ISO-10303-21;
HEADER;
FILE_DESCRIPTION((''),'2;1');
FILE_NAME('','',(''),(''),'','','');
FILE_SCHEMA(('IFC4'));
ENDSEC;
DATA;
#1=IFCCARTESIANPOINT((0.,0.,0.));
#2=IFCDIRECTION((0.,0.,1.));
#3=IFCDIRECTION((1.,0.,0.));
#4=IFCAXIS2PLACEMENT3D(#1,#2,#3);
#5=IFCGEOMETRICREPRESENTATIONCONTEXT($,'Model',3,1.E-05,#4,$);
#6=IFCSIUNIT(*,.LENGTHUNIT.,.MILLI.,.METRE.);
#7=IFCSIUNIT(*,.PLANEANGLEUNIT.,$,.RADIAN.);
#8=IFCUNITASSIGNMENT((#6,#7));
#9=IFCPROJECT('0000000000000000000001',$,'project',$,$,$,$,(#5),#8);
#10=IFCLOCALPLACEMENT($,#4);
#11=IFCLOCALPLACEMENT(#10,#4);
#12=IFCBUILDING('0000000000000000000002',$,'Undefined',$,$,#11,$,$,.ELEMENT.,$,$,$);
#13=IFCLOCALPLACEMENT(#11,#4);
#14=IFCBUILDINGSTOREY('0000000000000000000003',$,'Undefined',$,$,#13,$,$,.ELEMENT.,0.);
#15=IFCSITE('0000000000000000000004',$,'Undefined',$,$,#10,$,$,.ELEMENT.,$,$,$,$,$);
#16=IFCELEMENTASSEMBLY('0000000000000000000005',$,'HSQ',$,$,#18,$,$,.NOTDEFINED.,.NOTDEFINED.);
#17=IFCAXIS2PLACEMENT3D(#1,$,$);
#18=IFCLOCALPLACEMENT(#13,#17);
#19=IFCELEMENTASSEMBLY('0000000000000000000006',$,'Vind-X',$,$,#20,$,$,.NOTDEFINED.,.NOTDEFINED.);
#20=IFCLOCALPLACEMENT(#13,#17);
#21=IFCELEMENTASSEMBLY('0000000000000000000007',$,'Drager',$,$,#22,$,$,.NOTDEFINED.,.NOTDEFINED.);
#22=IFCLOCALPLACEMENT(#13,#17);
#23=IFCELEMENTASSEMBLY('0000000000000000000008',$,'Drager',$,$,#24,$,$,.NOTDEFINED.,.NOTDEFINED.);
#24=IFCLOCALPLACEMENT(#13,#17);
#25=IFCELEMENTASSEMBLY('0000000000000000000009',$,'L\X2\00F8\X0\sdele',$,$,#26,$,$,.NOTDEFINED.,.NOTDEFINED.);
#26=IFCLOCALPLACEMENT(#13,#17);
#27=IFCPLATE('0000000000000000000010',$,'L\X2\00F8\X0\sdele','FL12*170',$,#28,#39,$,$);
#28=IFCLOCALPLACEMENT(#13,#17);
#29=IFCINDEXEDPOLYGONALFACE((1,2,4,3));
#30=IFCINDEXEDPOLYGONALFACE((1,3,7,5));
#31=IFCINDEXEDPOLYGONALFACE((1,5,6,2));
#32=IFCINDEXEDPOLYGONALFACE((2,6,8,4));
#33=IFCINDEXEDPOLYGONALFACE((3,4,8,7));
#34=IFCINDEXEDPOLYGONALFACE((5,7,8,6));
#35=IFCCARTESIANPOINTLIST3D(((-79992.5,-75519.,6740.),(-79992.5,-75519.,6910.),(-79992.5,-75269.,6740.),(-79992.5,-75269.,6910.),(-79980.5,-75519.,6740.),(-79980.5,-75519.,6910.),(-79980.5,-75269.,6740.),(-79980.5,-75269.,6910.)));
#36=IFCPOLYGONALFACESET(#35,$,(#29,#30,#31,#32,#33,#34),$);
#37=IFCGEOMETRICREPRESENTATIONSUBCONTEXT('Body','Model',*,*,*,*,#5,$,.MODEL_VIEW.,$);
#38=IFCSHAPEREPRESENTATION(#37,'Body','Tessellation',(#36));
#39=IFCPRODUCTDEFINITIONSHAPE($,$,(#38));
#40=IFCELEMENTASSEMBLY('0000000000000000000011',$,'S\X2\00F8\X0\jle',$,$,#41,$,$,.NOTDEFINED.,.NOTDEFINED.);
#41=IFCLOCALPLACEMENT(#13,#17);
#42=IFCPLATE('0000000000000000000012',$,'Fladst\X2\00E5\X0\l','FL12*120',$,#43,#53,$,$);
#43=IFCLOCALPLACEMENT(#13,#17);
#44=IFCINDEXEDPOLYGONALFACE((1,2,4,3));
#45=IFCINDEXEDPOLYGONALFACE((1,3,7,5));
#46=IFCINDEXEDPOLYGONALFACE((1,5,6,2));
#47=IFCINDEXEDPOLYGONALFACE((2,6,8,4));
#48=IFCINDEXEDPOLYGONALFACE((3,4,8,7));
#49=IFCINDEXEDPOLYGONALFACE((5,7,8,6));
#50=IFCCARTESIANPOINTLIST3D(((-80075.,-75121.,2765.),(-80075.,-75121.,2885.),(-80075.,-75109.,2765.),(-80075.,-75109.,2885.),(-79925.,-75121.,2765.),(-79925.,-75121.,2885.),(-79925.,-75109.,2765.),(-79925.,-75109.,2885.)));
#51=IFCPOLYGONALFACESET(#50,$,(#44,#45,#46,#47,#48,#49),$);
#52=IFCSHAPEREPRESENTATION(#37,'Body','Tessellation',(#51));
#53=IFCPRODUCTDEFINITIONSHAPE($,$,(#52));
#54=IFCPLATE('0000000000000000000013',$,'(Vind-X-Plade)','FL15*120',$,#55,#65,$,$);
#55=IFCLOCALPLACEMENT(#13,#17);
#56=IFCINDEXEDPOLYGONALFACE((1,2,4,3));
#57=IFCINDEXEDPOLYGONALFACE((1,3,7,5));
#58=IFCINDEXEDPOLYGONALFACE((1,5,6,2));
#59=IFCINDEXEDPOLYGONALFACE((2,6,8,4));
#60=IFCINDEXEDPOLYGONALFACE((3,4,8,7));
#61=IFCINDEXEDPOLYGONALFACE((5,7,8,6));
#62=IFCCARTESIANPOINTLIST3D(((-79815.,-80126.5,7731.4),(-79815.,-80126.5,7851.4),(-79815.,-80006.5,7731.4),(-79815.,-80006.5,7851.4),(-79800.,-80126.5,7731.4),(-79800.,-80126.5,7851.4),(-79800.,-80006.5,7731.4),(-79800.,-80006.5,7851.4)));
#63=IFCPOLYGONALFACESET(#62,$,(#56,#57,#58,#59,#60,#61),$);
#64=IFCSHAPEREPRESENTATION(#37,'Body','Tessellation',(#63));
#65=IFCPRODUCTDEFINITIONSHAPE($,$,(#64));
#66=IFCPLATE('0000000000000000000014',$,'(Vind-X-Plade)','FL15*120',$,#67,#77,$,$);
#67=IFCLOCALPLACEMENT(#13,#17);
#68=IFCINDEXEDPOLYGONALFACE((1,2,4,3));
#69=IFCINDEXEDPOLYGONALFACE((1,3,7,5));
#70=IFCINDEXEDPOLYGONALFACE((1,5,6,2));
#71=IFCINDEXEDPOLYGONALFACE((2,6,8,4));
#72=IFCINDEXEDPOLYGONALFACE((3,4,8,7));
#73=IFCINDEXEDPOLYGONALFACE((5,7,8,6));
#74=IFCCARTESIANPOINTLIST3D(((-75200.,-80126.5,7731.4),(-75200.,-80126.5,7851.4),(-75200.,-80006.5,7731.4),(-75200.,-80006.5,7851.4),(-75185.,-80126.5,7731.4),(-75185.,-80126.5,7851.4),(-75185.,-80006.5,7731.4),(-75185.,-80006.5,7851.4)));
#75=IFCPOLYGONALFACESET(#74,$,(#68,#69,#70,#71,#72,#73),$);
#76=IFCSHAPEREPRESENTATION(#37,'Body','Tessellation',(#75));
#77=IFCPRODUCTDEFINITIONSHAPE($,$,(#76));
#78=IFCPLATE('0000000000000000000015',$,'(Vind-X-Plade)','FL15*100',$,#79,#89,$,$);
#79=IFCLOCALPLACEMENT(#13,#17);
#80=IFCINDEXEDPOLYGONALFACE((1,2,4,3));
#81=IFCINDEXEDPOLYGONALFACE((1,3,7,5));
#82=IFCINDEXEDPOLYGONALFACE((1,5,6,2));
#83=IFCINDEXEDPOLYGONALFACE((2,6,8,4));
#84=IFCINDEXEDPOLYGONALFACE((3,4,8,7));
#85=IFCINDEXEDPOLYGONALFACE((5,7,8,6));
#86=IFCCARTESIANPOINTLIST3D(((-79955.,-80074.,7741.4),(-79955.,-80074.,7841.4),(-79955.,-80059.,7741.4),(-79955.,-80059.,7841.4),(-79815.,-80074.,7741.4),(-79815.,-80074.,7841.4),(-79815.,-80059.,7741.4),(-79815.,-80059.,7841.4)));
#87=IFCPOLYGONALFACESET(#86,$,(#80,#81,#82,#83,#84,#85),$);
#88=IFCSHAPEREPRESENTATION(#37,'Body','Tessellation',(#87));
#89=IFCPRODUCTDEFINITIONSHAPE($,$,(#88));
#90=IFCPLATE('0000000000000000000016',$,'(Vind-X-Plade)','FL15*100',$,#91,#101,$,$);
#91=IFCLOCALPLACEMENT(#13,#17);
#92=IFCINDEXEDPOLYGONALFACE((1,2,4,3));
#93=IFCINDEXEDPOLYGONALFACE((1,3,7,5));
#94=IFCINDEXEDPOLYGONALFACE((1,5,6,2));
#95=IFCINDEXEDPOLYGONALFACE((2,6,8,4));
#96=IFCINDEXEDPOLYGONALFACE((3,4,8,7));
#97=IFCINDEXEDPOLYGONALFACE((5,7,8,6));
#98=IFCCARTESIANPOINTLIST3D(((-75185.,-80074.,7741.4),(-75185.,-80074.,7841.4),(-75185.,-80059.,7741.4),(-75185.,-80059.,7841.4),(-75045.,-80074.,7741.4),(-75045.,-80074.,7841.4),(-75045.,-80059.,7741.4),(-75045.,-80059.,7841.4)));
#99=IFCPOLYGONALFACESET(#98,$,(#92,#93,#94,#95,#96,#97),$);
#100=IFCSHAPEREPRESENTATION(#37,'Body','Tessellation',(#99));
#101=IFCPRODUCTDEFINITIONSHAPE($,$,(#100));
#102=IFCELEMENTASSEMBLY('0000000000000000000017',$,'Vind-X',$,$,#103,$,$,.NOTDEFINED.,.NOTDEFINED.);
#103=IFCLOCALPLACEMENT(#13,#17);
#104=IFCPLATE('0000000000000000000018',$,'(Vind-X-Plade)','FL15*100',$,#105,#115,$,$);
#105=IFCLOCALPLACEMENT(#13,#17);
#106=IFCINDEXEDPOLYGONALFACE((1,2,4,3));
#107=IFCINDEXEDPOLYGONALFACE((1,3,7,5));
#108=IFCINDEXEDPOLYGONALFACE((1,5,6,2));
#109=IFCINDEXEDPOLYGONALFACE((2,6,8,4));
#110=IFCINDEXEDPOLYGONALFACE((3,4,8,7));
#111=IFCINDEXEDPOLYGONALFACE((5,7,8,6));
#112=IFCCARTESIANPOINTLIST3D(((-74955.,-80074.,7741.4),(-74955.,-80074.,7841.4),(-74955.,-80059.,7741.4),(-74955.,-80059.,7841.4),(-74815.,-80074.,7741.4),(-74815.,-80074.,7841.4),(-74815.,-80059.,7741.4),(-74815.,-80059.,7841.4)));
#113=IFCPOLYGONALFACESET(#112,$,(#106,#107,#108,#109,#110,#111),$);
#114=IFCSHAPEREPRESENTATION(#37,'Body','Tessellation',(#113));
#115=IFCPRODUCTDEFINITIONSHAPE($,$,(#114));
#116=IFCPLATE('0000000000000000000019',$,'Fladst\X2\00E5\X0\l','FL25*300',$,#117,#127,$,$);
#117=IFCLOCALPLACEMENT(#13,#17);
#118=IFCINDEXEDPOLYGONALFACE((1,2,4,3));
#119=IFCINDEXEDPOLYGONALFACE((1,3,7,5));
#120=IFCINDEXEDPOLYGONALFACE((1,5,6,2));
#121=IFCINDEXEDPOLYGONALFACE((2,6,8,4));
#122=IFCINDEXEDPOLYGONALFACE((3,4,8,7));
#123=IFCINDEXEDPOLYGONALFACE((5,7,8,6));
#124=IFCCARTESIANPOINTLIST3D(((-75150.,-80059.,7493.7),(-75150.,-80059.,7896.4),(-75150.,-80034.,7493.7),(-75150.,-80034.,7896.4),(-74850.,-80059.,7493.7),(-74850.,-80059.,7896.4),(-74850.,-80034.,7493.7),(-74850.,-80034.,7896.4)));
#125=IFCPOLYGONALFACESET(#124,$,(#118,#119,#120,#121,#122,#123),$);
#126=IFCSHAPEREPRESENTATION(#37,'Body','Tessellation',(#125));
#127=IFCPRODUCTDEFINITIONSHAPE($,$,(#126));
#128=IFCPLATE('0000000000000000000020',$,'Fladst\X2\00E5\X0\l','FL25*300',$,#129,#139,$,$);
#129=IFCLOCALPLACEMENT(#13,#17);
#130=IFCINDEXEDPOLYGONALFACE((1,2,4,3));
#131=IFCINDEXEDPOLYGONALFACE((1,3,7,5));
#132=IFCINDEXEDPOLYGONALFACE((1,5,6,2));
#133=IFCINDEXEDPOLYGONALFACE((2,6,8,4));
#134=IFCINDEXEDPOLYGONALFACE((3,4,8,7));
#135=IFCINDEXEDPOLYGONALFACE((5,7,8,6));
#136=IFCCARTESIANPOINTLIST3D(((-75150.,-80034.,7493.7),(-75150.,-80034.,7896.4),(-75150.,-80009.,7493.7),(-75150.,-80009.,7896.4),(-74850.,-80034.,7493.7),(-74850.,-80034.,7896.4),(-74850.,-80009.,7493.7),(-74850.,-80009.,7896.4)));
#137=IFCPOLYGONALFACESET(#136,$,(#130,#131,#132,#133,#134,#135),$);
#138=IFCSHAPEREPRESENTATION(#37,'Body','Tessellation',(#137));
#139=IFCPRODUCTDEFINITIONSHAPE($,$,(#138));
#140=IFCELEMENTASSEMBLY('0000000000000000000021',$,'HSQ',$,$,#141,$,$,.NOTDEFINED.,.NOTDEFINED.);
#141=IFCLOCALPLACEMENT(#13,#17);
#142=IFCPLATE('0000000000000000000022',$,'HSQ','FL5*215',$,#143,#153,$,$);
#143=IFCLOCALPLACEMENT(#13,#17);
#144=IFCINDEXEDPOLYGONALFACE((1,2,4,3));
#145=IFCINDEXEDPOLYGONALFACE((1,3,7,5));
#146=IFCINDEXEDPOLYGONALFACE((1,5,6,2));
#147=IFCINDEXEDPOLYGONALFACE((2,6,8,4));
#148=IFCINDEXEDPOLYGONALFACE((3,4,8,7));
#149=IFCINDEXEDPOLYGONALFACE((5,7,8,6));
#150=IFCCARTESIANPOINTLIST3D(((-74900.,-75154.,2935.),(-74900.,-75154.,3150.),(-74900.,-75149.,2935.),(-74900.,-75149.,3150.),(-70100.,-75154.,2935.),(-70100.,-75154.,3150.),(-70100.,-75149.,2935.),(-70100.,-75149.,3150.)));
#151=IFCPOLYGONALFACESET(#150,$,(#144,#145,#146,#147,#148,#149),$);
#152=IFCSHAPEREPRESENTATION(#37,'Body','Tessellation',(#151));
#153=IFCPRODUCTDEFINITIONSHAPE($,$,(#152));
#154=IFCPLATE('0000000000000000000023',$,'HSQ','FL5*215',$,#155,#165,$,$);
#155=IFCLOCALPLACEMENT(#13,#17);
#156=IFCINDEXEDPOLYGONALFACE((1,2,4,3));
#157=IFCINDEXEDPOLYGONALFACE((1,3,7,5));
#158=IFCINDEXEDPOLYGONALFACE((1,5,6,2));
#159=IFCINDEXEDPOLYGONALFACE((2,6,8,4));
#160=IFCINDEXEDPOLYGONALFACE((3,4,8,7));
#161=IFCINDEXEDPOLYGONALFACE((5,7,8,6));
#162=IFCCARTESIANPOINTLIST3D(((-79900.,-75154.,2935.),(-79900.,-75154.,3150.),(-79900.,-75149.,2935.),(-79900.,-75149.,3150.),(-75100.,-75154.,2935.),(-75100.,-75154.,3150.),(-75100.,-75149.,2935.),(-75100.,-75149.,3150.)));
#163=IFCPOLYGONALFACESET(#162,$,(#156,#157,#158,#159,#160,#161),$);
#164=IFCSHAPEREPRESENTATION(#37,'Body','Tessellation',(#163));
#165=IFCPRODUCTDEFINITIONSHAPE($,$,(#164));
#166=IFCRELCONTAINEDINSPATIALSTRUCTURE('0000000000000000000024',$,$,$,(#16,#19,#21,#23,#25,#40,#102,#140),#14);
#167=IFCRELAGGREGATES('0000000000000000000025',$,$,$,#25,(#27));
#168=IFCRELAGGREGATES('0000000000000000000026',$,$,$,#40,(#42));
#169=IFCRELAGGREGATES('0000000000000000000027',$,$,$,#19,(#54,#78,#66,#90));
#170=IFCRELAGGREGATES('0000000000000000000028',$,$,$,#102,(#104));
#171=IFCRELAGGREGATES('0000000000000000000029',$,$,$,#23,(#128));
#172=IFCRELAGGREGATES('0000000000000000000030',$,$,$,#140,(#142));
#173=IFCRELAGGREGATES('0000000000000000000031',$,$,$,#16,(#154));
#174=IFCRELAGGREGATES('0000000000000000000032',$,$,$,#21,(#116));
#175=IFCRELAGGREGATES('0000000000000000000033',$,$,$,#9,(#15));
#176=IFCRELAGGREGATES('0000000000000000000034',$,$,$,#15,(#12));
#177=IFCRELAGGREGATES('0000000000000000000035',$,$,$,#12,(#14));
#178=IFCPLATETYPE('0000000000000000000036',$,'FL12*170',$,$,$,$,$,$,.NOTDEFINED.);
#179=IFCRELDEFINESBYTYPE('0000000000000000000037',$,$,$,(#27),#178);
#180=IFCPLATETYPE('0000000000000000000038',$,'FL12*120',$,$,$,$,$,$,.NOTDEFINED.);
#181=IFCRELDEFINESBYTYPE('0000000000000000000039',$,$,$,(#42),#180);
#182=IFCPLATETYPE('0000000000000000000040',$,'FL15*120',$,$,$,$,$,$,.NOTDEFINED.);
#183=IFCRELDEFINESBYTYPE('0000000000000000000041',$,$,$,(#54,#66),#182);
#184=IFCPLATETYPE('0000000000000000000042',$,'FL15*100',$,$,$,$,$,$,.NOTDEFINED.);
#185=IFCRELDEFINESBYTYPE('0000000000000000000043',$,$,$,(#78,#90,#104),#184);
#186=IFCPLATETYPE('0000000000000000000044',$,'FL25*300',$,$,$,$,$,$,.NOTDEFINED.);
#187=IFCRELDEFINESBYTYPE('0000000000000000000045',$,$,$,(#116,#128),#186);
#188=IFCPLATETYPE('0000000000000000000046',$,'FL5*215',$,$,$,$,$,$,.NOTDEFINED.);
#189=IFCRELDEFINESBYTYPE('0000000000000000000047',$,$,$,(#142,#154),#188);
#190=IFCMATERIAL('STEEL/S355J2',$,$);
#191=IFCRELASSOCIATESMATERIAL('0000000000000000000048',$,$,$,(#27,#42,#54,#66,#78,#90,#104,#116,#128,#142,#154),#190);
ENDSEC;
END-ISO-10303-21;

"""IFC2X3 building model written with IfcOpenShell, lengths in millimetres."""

from ifc_helpers import new_model, si_unit, frame, origin_with_axes, place, context, subcontext, project, spatial, polyline, outline, extrude, material, type_object, element, aggregate, save


model = new_model("IFC2X3")

# Units and contexts
model_context = context("Model", 3, precision=1e-05, world=origin_with_axes())
body_context = subcontext(model_context, "Body", "Model", "MODEL_VIEW")
ifc_project = project(units=[si_unit("LENGTHUNIT", "METRE", prefix="MILLI"), si_unit("PLANEANGLEUNIT", "RADIAN")], contexts=[model_context])

# Site, building, storey
site_placement = place(None, origin_with_axes())
site = spatial("IfcSite", under=ifc_project, at=site_placement, Name="Undefined", CompositionType="ELEMENT")
building_placement = place(site_placement, origin_with_axes())
building = spatial("IfcBuilding", under=site, at=building_placement, Name="Undefined", CompositionType="ELEMENT")
storey_placement = place(building_placement, origin_with_axes())
storey = spatial("IfcBuildingStorey", under=building, at=storey_placement, Name="Undefined", CompositionType="ELEMENT", Elevation=0.0)

# Element assembly
assembly_1_placement = place(storey_placement, origin_with_axes())
assembly_1 = element("IfcElementAssembly", 1, at=assembly_1_placement, inside=storey, Name="HSQ", AssemblyPlace="NOTDEFINED", PredefinedType="NOTDEFINED")

# Element assemblies
assembly_2_placement = place(storey_placement, origin_with_axes())
assembly_2 = element("IfcElementAssembly", 2, at=assembly_2_placement, inside=storey, Name="Vind-X", AssemblyPlace="NOTDEFINED", PredefinedType="NOTDEFINED")
assembly_3_placement = place(storey_placement, origin_with_axes())
assembly_3 = element("IfcElementAssembly", 3, at=assembly_3_placement, inside=storey, Name="Drager", AssemblyPlace="NOTDEFINED", PredefinedType="NOTDEFINED")
ifc_material_1 = material(Name="STEEL/S355J2")
assembly_4_placement = place(storey_placement, origin_with_axes())
assembly_4 = element("IfcElementAssembly", 4, at=assembly_4_placement, inside=storey, Name="Drager", AssemblyPlace="NOTDEFINED", PredefinedType="NOTDEFINED")

# Element assemblies, plates
plate_type_1 = type_object("IfcPlateType", Name="FL12*170", PredefinedType="NOTDEFINED")
assembly_5_placement = place(storey_placement, origin_with_axes())
assembly_5 = element("IfcElementAssembly", 5, at=assembly_5_placement, inside=storey, Name="Løsdele", AssemblyPlace="NOTDEFINED", PredefinedType="NOTDEFINED")
plate_1_placement = place(assembly_5_placement, frame((-79986.5, -75269.0, 6825.0), z_axis=(-1.0, 0.0, 0.0), x_axis=(0.0, -1.0, 0.0)))
plate_1 = element("IfcPlate", 6, at=plate_1_placement, type_object=plate_type_1, material=ifc_material_1, Name="Løsdele", Description="FL12*170", context=body_context, shape_type="SweptSolid", body=[
    extrude(outline(polyline([(0.0, -85.0), (0.0, 85.0), (250.0, 85.0), (250.0, -85.0), (0.0, -85.0)])), frame((0.0, 0.0, -6.0), z_axis=(0.0, 0.0, 1.0), x_axis=(1.0, 0.0, 0.0)), (0.0, 0.0, 1.0), 12.0),
])
aggregate(assembly_5, [plate_1])
assembly_6_placement = place(storey_placement, origin_with_axes())
assembly_6 = element("IfcElementAssembly", 7, at=assembly_6_placement, inside=storey, Name="Søjle", AssemblyPlace="NOTDEFINED", PredefinedType="NOTDEFINED")
plate_type_2 = type_object("IfcPlateType", Name="FL12*120", PredefinedType="NOTDEFINED")
plate_2_placement = place(assembly_6_placement, frame((-79925.0, -75115.0, 2885.0), z_axis=(0.0, -1.0, 0.0), x_axis=(-1.0, 0.0, 0.0)))
plate_2 = element("IfcPlate", 8, at=plate_2_placement, type_object=plate_type_2, material=ifc_material_1, Name="Fladstål", Description="FL12*120", context=body_context, shape_type="SweptSolid", body=[
    extrude(outline(polyline([(0.0, 0.0), (150.0, 0.0), (150.0, 120.0), (0.0, 120.0), (0.0, 0.0)])), frame((0.0, 0.0, -6.0), z_axis=(0.0, 0.0, 1.0), x_axis=(1.0, 0.0, 0.0)), (0.0, 0.0, 1.0), 12.0),
])
aggregate(assembly_6, [plate_2])

# Plates
plate_type_3 = type_object("IfcPlateType", Name="FL15*120", PredefinedType="NOTDEFINED")
plate_3_placement = place(assembly_2_placement, frame((-79807.5, -80126.5, 7851.4), z_axis=(-1.0, 0.0, 0.0), x_axis=(0.0, 1.0, 0.0)))
plate_3 = element("IfcPlate", 9, at=plate_3_placement, type_object=plate_type_3, material=ifc_material_1, Name="(Vind-X-Plade)", Description="FL15*120", context=body_context, shape_type="SweptSolid", body=[
    extrude(outline(polyline([(0.0, 0.0), (120.0, 0.0), (120.0, 120.0), (0.0, 120.0), (0.0, 0.0)])), frame((0.0, 0.0, -7.5), z_axis=(0.0, 0.0, 1.0), x_axis=(1.0, 0.0, 0.0)), (0.0, 0.0, 1.0), 15.0),
])
plate_4_placement = place(assembly_2_placement, frame((-75192.5, -80006.5, 7851.4), z_axis=(1.0, 0.0, 0.0), x_axis=(0.0, -1.0, 0.0)))
plate_4 = element("IfcPlate", 10, at=plate_4_placement, type_object=plate_type_3, material=ifc_material_1, Name="(Vind-X-Plade)", Description="FL15*120", context=body_context, shape_type="SweptSolid", body=[
    extrude(outline(polyline([(0.0, 0.0), (120.0, 0.0), (120.0, 120.0), (0.0, 120.0), (0.0, 0.0)])), frame((0.0, 0.0, -7.5), z_axis=(0.0, 0.0, 1.0), x_axis=(1.0, 0.0, 0.0)), (0.0, 0.0, 1.0), 15.0),
])
plate_type_4 = type_object("IfcPlateType", Name="FL15*100", PredefinedType="NOTDEFINED")
plate_5_placement = place(assembly_2_placement, frame((-79955.0, -80066.5, 7741.4), z_axis=(0.0, 1.0, 0.0), x_axis=(0.0, 0.0, 1.0)))
plate_5 = element("IfcPlate", 11, at=plate_5_placement, type_object=plate_type_4, material=ifc_material_1, Name="(Vind-X-Plade)", Description="FL15*100", context=body_context, shape_type="SweptSolid", body=[
    extrude(outline(polyline([(0.0, 0.0), (100.0, 0.0), (100.0, 140.0), (0.0, 140.0), (0.0, 0.0)])), frame((0.0, 0.0, -7.5), z_axis=(0.0, 0.0, 1.0), x_axis=(1.0, 0.0, 0.0)), (0.0, 0.0, 1.0), 15.0),
])
plate_6_placement = place(assembly_2_placement, frame((-75045.0, -80066.5, 7741.4), z_axis=(0.0, -1.0, 0.0), x_axis=(0.0, 0.0, 1.0)))
plate_6 = element("IfcPlate", 12, at=plate_6_placement, type_object=plate_type_4, material=ifc_material_1, Name="(Vind-X-Plade)", Description="FL15*100", context=body_context, shape_type="SweptSolid", body=[
    extrude(outline(polyline([(0.0, 0.0), (100.0, 0.0), (100.0, 140.0), (0.0, 140.0), (0.0, 0.0)])), frame((0.0, 0.0, -7.5), z_axis=(0.0, 0.0, 1.0), x_axis=(1.0, 0.0, 0.0)), (0.0, 0.0, 1.0), 15.0),
])
aggregate(assembly_2, [plate_3, plate_5, plate_4, plate_6])

# Element assembly, plate
assembly_7_placement = place(storey_placement, origin_with_axes())
assembly_7 = element("IfcElementAssembly", 13, at=assembly_7_placement, inside=storey, Name="Vind-X", AssemblyPlace="NOTDEFINED", PredefinedType="NOTDEFINED")
plate_7_placement = place(assembly_7_placement, frame((-74955.0, -80066.5, 7741.4), z_axis=(0.0, 1.0, 0.0), x_axis=(0.0, 0.0, 1.0)))
plate_7 = element("IfcPlate", 14, at=plate_7_placement, type_object=plate_type_4, material=ifc_material_1, Name="(Vind-X-Plade)", Description="FL15*100", context=body_context, shape_type="SweptSolid", body=[
    extrude(outline(polyline([(0.0, 0.0), (100.0, 0.0), (100.0, 140.0), (0.0, 140.0), (0.0, 0.0)])), frame((0.0, 0.0, -7.5), z_axis=(0.0, 0.0, 1.0), x_axis=(1.0, 0.0, 0.0)), (0.0, 0.0, 1.0), 15.0),
])
aggregate(assembly_7, [plate_7])

# Plates
plate_type_5 = type_object("IfcPlateType", Name="FL25*300", PredefinedType="NOTDEFINED")
plate_8_placement = place(assembly_3_placement, frame((-75000.0, -80046.5, 7493.7), z_axis=(0.0, -1.0, 0.0), x_axis=(0.0, 0.0, 1.0)))
plate_8 = element("IfcPlate", 15, at=plate_8_placement, type_object=plate_type_5, material=ifc_material_1, Name="Fladstål", Description="FL25*300", context=body_context, shape_type="SweptSolid", body=[
    extrude(outline(polyline([(0.0, -150.0), (0.0, 150.0), (402.7, 150.0), (402.7, -150.0), (0.0, -150.0)])), frame((0.0, 0.0, -12.5), z_axis=(0.0, 0.0, 1.0), x_axis=(1.0, 0.0, 0.0)), (0.0, 0.0, 1.0), 25.0),
])
plate_9_placement = place(assembly_4_placement, frame((-75000.0, -80021.5, 7493.7), z_axis=(0.0, -1.0, 0.0), x_axis=(0.0, 0.0, 1.0)))
plate_9 = element("IfcPlate", 16, at=plate_9_placement, type_object=plate_type_5, material=ifc_material_1, Name="Fladstål", Description="FL25*300", context=body_context, shape_type="SweptSolid", body=[
    extrude(outline(polyline([(0.0, -150.0), (0.0, 150.0), (402.7, 150.0), (402.7, -150.0), (0.0, -150.0)])), frame((0.0, 0.0, -12.5), z_axis=(0.0, 0.0, 1.0), x_axis=(1.0, 0.0, 0.0)), (0.0, 0.0, 1.0), 25.0),
])
aggregate(assembly_4, [plate_9])

# Element assembly, plate
assembly_8_placement = place(storey_placement, origin_with_axes())
assembly_8 = element("IfcElementAssembly", 17, at=assembly_8_placement, inside=storey, Name="HSQ", AssemblyPlace="NOTDEFINED", PredefinedType="NOTDEFINED")
plate_type_6 = type_object("IfcPlateType", Name="FL5*215", PredefinedType="NOTDEFINED")
plate_10_placement = place(assembly_8_placement, frame((-74900.0, -75151.5, 3042.5), z_axis=(0.0, -1.0, 0.0), x_axis=(1.0, 0.0, 0.0)))
plate_10 = element("IfcPlate", 18, at=plate_10_placement, type_object=plate_type_6, material=ifc_material_1, Name="HSQ", Description="FL5*215", context=body_context, shape_type="SweptSolid", body=[
    extrude(outline(polyline([(0.0, -107.5), (0.0, 107.5), (4800.0, 107.5), (4800.0, -107.5), (0.0, -107.5)])), frame((0.0, 0.0, -2.5), z_axis=(0.0, 0.0, 1.0), x_axis=(1.0, 0.0, 0.0)), (0.0, 0.0, 1.0), 5.0),
])

# Plate
plate_11_placement = place(assembly_1_placement, frame((-79900.0, -75151.5, 3042.5), z_axis=(0.0, -1.0, 0.0), x_axis=(1.0, 0.0, 0.0)))
plate_11 = element("IfcPlate", 19, at=plate_11_placement, type_object=plate_type_6, material=ifc_material_1, Name="HSQ", Description="FL5*215", context=body_context, shape_type="SweptSolid", body=[
    extrude(outline(polyline([(0.0, -107.5), (0.0, 107.5), (4800.0, 107.5), (4800.0, -107.5), (0.0, -107.5)])), frame((0.0, 0.0, -2.5), z_axis=(0.0, 0.0, 1.0), x_axis=(1.0, 0.0, 0.0)), (0.0, 0.0, 1.0), 5.0),
])

aggregate(assembly_8, [plate_10])
aggregate(assembly_1, [plate_11])

aggregate(assembly_3, [plate_8])

save(model, "model.ifc")
